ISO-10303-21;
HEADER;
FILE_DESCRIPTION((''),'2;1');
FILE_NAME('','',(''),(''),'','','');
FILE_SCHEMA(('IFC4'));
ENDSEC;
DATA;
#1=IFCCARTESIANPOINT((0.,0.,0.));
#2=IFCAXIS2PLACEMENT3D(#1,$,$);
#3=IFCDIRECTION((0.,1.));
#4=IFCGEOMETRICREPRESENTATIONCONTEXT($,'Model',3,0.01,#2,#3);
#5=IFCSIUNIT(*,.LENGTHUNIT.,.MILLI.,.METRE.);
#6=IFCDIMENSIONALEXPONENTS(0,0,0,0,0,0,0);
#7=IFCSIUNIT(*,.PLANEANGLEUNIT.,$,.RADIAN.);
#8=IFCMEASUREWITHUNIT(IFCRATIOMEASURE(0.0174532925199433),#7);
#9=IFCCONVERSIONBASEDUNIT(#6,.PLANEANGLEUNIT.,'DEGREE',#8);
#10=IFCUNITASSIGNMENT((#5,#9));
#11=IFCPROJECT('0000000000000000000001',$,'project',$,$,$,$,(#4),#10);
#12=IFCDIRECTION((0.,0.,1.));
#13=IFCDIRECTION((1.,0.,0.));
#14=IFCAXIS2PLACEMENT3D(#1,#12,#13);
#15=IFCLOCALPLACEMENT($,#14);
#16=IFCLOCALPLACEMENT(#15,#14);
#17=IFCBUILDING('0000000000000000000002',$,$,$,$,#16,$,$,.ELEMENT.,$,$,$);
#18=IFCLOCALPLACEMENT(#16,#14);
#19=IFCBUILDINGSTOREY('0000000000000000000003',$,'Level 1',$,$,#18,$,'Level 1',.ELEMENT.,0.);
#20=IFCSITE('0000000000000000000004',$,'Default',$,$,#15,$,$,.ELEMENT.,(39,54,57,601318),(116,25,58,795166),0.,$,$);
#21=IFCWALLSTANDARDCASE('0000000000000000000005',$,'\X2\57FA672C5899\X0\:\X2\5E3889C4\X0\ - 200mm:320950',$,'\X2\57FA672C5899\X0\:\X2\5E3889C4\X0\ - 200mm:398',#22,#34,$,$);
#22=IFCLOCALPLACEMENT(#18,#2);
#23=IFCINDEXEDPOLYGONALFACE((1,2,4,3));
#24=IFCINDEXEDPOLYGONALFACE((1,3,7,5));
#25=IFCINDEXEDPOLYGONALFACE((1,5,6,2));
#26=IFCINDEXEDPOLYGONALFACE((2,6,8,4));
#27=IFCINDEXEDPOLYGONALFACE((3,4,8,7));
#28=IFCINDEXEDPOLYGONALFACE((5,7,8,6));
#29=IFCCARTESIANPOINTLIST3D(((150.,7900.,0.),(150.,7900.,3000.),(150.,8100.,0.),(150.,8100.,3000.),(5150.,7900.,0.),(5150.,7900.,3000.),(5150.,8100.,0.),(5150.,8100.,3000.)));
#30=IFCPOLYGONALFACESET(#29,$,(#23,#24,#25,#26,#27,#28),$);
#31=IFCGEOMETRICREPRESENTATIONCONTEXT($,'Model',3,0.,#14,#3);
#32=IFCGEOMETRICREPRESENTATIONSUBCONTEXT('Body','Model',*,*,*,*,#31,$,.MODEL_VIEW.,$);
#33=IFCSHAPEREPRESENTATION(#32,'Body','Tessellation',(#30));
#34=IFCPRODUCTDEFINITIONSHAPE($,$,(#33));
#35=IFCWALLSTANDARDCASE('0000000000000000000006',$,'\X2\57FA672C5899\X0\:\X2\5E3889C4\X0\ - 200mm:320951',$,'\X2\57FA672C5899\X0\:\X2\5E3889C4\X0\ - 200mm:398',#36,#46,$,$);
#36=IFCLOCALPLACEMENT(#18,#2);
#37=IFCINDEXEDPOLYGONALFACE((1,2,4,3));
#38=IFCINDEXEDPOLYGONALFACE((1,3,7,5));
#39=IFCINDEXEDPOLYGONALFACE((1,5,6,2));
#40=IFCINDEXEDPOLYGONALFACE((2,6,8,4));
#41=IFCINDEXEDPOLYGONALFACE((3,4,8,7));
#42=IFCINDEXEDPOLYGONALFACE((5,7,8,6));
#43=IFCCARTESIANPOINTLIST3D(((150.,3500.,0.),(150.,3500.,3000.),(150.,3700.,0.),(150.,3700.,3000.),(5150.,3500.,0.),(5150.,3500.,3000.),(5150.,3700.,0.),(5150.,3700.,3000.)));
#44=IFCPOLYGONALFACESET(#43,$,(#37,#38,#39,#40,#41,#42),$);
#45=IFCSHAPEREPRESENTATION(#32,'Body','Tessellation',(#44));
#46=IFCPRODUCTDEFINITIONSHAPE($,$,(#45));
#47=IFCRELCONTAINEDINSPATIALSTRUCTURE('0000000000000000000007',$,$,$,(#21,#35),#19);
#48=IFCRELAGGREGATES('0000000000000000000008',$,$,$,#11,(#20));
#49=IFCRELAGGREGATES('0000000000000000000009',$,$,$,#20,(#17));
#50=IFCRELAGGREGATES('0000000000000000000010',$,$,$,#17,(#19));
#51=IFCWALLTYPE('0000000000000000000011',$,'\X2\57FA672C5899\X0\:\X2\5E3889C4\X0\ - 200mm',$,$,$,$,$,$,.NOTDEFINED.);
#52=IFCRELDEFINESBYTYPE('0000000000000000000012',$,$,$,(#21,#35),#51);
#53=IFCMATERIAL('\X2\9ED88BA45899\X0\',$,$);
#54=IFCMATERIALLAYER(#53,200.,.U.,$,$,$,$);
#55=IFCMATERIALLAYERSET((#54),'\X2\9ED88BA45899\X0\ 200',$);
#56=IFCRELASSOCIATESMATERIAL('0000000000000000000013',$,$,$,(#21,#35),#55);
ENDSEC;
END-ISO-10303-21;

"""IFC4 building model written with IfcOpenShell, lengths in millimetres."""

from ifc_helpers import new_model, entity, si_unit, converted_unit, direction, frame, origin, origin_with_axes, place, context, subcontext, project, spatial, polyline, outline, extrude, material, layer, layer_set, layer_usage, type_object, element, save


model = new_model("IFC4")

# Units and contexts
model_context_1 = context("Model", 3, precision=0.01, world=origin(), true_north=direction((0.0, 1.0)))
model_context_2 = context("Model", 3, precision=0.0, world=origin_with_axes(), true_north=direction((0.0, 1.0)))
body_context = subcontext(model_context_2, "Body", "Model", "MODEL_VIEW")
ifc_project = project(units=[si_unit("LENGTHUNIT", "METRE", prefix="MILLI"), converted_unit("PLANEANGLEUNIT", "DEGREE", entity("IfcRatioMeasure", 0.0174532925199433), si_unit("PLANEANGLEUNIT", "RADIAN"), dimensions=[0, 0, 0, 0, 0, 0, 0])], contexts=[model_context_1])

# Site, building, storey
site_placement = place(None, origin_with_axes())
site = spatial("IfcSite", under=ifc_project, at=site_placement, Name="Default", CompositionType="ELEMENT", RefLatitude=(39, 54, 57, 601318), RefLongitude=(116, 25, 58, 795166), RefElevation=0.0)
building_placement = place(site_placement, origin_with_axes())
building = spatial("IfcBuilding", under=site, at=building_placement, CompositionType="ELEMENT")
storey_placement = place(building_placement, origin_with_axes())
storey = spatial("IfcBuildingStorey", under=building, at=storey_placement, Name="Level 1", LongName="Level 1", CompositionType="ELEMENT", Elevation=0.0)

# Shared definitions
ifc_material = material(Name="默认墙")
ifc_layer = layer(ifc_material, 200.0, ventilated="UNKNOWN")
ifc_layer_set = layer_set([ifc_layer], Name="默认墙 200")
wall_type = type_object("IfcWallType", Name="基本墙:常规 - 200mm", PredefinedType="NOTDEFINED")

# Walls
ifc_layer_usage_1 = layer_usage(ifc_layer_set, "AXIS2", "POSITIVE", -100.0)
wall_1_placement = place(storey_placement, frame((150.0, 8000.0, 0.0), z_axis=(0.0, 0.0, 1.0), x_axis=(1.0, 0.0, 0.0)))
element("IfcWallStandardCase", 1, at=wall_1_placement, inside=storey, type_object=wall_type, material=ifc_layer_usage_1, Name="基本墙:常规 - 200mm:320950", ObjectType="基本墙:常规 - 200mm:398", context=body_context, shape_type="SweptSolid", body=[
    extrude(outline(polyline([(0.0, -100.0), (5000.0, -100.0), (5000.0, 100.0), (0.0, 100.0), (0.0, -100.0)])), origin_with_axes(), (0.0, 0.0, 1.0), 3000.0),
])
ifc_layer_usage_2 = layer_usage(ifc_layer_set, "AXIS2", "POSITIVE", -100.0)
wall_2_placement = place(storey_placement, frame((150.0, 3600.0, 0.0), z_axis=(0.0, 0.0, 1.0), x_axis=(1.0, 0.0, 0.0)))
element("IfcWallStandardCase", 2, at=wall_2_placement, inside=storey, type_object=wall_type, material=ifc_layer_usage_2, Name="基本墙:常规 - 200mm:320951", ObjectType="基本墙:常规 - 200mm:398", context=body_context, shape_type="SweptSolid", body=[
    extrude(outline(polyline([(0.0, -100.0), (5000.0, -100.0), (5000.0, 100.0), (0.0, 100.0), (0.0, -100.0)])), origin_with_axes(), (0.0, 0.0, 1.0), 3000.0),
])

save(model, "model.ifc")
